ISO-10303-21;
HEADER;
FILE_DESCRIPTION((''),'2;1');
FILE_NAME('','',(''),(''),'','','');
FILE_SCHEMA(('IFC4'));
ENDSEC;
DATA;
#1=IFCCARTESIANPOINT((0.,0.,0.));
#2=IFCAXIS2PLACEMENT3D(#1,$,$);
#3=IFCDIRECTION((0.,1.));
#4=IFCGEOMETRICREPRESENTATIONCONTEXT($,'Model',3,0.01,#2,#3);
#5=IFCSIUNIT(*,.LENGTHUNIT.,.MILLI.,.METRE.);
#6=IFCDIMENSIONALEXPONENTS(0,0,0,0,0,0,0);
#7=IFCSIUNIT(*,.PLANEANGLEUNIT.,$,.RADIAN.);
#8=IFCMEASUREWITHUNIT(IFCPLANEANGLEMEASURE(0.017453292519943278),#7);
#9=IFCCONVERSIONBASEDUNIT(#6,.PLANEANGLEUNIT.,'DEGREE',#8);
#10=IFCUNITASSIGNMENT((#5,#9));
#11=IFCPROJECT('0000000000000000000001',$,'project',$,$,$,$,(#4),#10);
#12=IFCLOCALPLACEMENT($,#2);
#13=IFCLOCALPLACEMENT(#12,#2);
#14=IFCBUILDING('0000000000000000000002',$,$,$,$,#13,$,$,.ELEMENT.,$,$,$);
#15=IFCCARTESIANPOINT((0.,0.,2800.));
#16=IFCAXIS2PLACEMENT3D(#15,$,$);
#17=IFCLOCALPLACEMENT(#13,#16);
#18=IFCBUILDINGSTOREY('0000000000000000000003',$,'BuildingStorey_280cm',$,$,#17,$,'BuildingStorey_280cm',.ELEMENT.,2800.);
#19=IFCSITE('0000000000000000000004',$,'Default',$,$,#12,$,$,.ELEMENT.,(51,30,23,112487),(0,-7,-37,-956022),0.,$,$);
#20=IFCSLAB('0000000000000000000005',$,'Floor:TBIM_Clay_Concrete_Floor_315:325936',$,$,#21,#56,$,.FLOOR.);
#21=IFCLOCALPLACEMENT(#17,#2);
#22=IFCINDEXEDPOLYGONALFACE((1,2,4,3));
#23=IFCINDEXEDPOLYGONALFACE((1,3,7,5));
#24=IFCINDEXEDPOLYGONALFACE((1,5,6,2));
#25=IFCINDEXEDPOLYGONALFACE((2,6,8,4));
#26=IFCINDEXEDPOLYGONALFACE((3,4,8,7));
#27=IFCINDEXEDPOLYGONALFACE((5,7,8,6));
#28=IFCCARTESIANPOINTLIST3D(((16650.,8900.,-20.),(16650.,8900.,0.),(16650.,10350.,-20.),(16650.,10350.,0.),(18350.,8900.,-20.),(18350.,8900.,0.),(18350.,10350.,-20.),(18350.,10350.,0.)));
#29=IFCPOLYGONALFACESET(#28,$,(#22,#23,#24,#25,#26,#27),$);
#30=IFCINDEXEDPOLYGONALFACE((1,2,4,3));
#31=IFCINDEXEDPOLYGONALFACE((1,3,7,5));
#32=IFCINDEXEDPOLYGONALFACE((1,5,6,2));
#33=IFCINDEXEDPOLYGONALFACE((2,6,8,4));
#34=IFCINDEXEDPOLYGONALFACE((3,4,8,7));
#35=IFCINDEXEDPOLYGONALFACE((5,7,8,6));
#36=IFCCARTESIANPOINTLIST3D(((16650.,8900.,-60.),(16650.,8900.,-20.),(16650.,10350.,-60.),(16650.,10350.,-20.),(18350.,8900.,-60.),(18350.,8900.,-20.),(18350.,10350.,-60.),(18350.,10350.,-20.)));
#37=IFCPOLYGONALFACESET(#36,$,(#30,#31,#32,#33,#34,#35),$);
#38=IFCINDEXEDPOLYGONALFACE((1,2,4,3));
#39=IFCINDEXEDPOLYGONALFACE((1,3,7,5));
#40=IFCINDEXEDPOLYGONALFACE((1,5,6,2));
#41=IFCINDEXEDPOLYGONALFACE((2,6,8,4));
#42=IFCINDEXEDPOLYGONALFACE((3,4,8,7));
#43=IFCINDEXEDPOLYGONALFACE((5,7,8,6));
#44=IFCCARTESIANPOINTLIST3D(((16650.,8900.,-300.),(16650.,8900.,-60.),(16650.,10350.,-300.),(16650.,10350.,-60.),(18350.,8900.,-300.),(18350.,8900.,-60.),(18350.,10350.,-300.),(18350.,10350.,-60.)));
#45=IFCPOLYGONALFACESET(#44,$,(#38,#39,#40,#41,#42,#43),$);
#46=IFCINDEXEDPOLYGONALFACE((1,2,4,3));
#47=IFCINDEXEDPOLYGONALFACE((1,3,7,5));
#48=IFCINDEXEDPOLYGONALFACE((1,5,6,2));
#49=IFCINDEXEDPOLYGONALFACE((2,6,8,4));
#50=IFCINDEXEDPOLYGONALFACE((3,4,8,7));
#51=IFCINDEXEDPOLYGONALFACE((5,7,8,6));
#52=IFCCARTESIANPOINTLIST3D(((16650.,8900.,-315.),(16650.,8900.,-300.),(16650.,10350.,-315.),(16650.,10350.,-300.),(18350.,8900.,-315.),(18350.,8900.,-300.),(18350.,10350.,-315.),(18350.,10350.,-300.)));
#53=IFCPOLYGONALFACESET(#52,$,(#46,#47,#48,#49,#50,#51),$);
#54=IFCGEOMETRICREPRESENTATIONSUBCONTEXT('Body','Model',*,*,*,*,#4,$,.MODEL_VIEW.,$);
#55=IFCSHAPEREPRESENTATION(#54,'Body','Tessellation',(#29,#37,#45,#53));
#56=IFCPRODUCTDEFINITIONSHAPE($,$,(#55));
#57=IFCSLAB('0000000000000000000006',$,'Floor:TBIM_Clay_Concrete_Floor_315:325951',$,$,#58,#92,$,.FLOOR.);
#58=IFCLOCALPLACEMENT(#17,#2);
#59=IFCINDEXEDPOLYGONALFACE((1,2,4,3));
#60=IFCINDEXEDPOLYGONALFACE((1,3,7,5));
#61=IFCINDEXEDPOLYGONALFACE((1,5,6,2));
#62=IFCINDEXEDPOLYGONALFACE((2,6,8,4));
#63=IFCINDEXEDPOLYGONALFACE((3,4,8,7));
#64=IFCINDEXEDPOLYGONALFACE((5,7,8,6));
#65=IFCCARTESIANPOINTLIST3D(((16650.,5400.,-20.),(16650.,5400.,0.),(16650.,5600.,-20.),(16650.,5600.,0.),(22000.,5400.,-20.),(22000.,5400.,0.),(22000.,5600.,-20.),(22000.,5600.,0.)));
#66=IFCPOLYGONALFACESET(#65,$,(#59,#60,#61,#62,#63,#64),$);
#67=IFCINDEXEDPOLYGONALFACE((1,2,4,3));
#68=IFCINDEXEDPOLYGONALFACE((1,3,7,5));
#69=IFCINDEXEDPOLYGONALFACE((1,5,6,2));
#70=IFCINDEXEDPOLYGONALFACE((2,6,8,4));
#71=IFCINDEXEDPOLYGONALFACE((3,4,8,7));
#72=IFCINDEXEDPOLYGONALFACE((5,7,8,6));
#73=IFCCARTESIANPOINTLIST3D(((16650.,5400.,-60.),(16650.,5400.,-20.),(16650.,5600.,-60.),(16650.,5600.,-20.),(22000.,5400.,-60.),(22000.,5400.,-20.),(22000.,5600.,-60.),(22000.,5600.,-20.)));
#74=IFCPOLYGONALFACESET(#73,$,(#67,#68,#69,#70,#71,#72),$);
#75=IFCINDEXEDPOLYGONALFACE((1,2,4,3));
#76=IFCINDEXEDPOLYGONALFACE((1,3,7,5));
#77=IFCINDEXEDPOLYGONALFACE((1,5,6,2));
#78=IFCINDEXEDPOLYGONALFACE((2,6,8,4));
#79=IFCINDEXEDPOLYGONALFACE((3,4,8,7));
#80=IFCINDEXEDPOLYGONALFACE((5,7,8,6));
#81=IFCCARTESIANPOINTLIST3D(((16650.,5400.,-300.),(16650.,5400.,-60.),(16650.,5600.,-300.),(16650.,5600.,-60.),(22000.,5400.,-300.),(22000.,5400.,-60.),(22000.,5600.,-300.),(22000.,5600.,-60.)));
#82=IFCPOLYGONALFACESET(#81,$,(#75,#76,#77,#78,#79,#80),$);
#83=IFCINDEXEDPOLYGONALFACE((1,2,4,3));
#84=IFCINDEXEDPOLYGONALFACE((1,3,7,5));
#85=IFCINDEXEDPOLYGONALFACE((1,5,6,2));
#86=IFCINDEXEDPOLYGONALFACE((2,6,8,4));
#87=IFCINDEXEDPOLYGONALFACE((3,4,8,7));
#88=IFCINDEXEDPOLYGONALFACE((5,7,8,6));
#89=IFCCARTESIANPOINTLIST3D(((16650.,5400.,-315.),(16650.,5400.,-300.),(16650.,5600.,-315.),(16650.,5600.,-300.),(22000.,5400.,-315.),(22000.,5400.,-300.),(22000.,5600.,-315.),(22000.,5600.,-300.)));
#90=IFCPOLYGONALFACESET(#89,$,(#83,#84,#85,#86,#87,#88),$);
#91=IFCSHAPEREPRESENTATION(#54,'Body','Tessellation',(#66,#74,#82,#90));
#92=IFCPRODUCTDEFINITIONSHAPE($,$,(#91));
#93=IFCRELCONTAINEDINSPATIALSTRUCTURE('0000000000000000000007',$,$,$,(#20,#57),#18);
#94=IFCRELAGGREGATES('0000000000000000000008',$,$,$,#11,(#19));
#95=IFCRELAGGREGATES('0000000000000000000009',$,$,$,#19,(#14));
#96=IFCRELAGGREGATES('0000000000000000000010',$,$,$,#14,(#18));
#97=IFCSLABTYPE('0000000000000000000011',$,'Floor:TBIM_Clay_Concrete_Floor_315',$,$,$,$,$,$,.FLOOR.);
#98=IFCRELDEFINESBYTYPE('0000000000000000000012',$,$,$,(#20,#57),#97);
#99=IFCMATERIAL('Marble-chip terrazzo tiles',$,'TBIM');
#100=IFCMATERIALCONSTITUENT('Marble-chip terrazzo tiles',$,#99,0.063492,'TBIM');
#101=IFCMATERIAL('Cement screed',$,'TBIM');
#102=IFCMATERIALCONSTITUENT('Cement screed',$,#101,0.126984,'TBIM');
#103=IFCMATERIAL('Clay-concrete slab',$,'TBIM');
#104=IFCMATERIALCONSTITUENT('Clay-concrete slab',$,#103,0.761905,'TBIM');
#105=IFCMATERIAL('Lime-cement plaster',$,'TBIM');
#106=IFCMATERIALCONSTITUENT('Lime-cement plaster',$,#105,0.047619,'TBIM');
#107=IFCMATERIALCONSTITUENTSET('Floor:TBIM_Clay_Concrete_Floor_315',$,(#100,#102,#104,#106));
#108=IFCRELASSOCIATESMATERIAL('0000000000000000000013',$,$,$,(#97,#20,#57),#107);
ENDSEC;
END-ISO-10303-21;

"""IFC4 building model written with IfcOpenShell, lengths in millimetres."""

from ifc_helpers import new_model, entity, si_unit, converted_unit, direction, frame, origin, place, context, subcontext, project, spatial, indexed_curve, outline, extrude, material, constituent, constituent_set, type_object, element, save


model = new_model("IFC4")

# Units and contexts
model_context = context("Model", 3, precision=0.01, world=origin(), true_north=direction((0.0, 1.0)))
body_context = subcontext(model_context, "Body", "Model", "MODEL_VIEW")
ifc_project = project(units=[si_unit("LENGTHUNIT", "METRE", prefix="MILLI"), converted_unit("PLANEANGLEUNIT", "DEGREE", entity("IfcPlaneAngleMeasure", 0.017453292519943278), si_unit("PLANEANGLEUNIT", "RADIAN"), dimensions=[0, 0, 0, 0, 0, 0, 0])], contexts=[model_context])

# Site, building, storey
site_placement = place(None, origin())
site = spatial("IfcSite", under=ifc_project, at=site_placement, Name="Default", CompositionType="ELEMENT", RefLatitude=(51, 30, 23, 112487), RefLongitude=(0, -7, -37, -956022), RefElevation=0.0)
building_placement = place(site_placement, origin())
building = spatial("IfcBuilding", under=site, at=building_placement, CompositionType="ELEMENT")
storey_placement = place(building_placement, frame((0.0, 0.0, 2800.0)))
storey = spatial("IfcBuildingStorey", under=building, at=storey_placement, Name="BuildingStorey_280cm", LongName="BuildingStorey_280cm", CompositionType="ELEMENT", Elevation=2800.0)

# Slabs
ifc_material_1 = material(Name="Marble-chip terrazzo tiles", Category="TBIM")
ifc_material_2 = material(Name="Cement screed", Category="TBIM")
ifc_material_3 = material(Name="Lime-cement plaster", Category="TBIM")
ifc_constituent_1 = constituent(ifc_material_1, Name="Marble-chip terrazzo tiles", Category="TBIM", fraction=0.063492)
ifc_constituent_2 = constituent(ifc_material_2, Name="Cement screed", Category="TBIM", fraction=0.126984)
ifc_material_4 = material(Name="Clay-concrete slab", Category="TBIM")
ifc_constituent_3 = constituent(ifc_material_4, Name="Clay-concrete slab", Category="TBIM", fraction=0.761905)
ifc_constituent_4 = constituent(ifc_material_3, Name="Lime-cement plaster", Category="TBIM", fraction=0.047619)
ifc_constituent_set_1 = constituent_set(constituents=[ifc_constituent_1, ifc_constituent_2, ifc_constituent_3, ifc_constituent_4], Name="Floor:TBIM_Clay_Concrete_Floor_315")
slab_type_1 = type_object("IfcSlabType", Name="Floor:TBIM_Clay_Concrete_Floor_315", PredefinedType="FLOOR", material=ifc_constituent_set_1)
slab_1_placement = place(storey_placement, origin())
element("IfcSlab", 1, at=slab_1_placement, inside=storey, type_object=slab_type_1, material=ifc_constituent_set_1, Name="Floor:TBIM_Clay_Concrete_Floor_315:325936", PredefinedType="FLOOR", context=body_context, shape_type="SweptSolid", body=[
    extrude(outline(indexed_curve([(-850.0, -725.0), (850.0, -725.0), (850.0, 725.0), (-850.0, 725.0), (-850.0, -725.0)], self_intersect=False)), frame((17500.0, 9625.0, -20.0), z_axis=(0.0, 0.0, 1.0), x_axis=(-1.0, 0.0, 0.0)), (0.0, 0.0, 1.0), 20.0),
    extrude(outline(indexed_curve([(-850.0, -725.0), (850.0, -725.0), (850.0, 725.0), (-850.0, 725.0), (-850.0, -725.0)], self_intersect=False)), frame((17500.0, 9625.0, -60.0), z_axis=(0.0, 0.0, 1.0), x_axis=(-1.0, 0.0, 0.0)), (0.0, 0.0, 1.0), 40.0),
    extrude(outline(indexed_curve([(-850.0, -725.0), (850.0, -725.0), (850.0, 725.0), (-850.0, 725.0), (-850.0, -725.0)], self_intersect=False)), frame((17500.0, 9625.0, -300.0), z_axis=(0.0, 0.0, 1.0), x_axis=(-1.0, 0.0, 0.0)), (0.0, 0.0, 1.0), 240.0),
    extrude(outline(indexed_curve([(-850.0, -725.0), (850.0, -725.0), (850.0, 725.0), (-850.0, 725.0), (-850.0, -725.0)], self_intersect=False)), frame((17500.0, 9625.0, -315.0), z_axis=(0.0, 0.0, 1.0), x_axis=(-1.0, 0.0, 0.0)), (0.0, 0.0, 1.0), 15.0),
])
slab_2_placement = place(storey_placement, origin())
element("IfcSlab", 2, at=slab_2_placement, inside=storey, type_object=slab_type_1, material=ifc_constituent_set_1, Name="Floor:TBIM_Clay_Concrete_Floor_315:325951", PredefinedType="FLOOR", context=body_context, shape_type="SweptSolid", body=[
    extrude(outline(indexed_curve([(-2675.0, -100.0), (2675.0, -100.0), (2675.0, 100.0), (-2675.0, 100.0), (-2675.0, -100.0)], self_intersect=False)), frame((19325.0, 5500.0, -20.0), z_axis=(0.0, 0.0, 1.0), x_axis=(-1.0, 0.0, 0.0)), (0.0, 0.0, 1.0), 20.0),
    extrude(outline(indexed_curve([(-2675.0, -100.0), (2675.0, -100.0), (2675.0, 100.0), (-2675.0, 100.0), (-2675.0, -100.0)], self_intersect=False)), frame((19325.0, 5500.0, -60.0), z_axis=(0.0, 0.0, 1.0), x_axis=(-1.0, 0.0, 0.0)), (0.0, 0.0, 1.0), 40.0),
    extrude(outline(indexed_curve([(-2675.0, -100.0), (2675.0, -100.0), (2675.0, 100.0), (-2675.0, 100.0), (-2675.0, -100.0)], self_intersect=False)), frame((19325.0, 5500.0, -300.0), z_axis=(0.0, 0.0, 1.0), x_axis=(-1.0, 0.0, 0.0)), (0.0, 0.0, 1.0), 240.0),
    extrude(outline(indexed_curve([(-2675.0, -100.0), (2675.0, -100.0), (2675.0, 100.0), (-2675.0, 100.0), (-2675.0, -100.0)], self_intersect=False)), frame((19325.0, 5500.0, -315.0), z_axis=(0.0, 0.0, 1.0), x_axis=(-1.0, 0.0, 0.0)), (0.0, 0.0, 1.0), 15.0),
])

save(model, "model.ifc")
